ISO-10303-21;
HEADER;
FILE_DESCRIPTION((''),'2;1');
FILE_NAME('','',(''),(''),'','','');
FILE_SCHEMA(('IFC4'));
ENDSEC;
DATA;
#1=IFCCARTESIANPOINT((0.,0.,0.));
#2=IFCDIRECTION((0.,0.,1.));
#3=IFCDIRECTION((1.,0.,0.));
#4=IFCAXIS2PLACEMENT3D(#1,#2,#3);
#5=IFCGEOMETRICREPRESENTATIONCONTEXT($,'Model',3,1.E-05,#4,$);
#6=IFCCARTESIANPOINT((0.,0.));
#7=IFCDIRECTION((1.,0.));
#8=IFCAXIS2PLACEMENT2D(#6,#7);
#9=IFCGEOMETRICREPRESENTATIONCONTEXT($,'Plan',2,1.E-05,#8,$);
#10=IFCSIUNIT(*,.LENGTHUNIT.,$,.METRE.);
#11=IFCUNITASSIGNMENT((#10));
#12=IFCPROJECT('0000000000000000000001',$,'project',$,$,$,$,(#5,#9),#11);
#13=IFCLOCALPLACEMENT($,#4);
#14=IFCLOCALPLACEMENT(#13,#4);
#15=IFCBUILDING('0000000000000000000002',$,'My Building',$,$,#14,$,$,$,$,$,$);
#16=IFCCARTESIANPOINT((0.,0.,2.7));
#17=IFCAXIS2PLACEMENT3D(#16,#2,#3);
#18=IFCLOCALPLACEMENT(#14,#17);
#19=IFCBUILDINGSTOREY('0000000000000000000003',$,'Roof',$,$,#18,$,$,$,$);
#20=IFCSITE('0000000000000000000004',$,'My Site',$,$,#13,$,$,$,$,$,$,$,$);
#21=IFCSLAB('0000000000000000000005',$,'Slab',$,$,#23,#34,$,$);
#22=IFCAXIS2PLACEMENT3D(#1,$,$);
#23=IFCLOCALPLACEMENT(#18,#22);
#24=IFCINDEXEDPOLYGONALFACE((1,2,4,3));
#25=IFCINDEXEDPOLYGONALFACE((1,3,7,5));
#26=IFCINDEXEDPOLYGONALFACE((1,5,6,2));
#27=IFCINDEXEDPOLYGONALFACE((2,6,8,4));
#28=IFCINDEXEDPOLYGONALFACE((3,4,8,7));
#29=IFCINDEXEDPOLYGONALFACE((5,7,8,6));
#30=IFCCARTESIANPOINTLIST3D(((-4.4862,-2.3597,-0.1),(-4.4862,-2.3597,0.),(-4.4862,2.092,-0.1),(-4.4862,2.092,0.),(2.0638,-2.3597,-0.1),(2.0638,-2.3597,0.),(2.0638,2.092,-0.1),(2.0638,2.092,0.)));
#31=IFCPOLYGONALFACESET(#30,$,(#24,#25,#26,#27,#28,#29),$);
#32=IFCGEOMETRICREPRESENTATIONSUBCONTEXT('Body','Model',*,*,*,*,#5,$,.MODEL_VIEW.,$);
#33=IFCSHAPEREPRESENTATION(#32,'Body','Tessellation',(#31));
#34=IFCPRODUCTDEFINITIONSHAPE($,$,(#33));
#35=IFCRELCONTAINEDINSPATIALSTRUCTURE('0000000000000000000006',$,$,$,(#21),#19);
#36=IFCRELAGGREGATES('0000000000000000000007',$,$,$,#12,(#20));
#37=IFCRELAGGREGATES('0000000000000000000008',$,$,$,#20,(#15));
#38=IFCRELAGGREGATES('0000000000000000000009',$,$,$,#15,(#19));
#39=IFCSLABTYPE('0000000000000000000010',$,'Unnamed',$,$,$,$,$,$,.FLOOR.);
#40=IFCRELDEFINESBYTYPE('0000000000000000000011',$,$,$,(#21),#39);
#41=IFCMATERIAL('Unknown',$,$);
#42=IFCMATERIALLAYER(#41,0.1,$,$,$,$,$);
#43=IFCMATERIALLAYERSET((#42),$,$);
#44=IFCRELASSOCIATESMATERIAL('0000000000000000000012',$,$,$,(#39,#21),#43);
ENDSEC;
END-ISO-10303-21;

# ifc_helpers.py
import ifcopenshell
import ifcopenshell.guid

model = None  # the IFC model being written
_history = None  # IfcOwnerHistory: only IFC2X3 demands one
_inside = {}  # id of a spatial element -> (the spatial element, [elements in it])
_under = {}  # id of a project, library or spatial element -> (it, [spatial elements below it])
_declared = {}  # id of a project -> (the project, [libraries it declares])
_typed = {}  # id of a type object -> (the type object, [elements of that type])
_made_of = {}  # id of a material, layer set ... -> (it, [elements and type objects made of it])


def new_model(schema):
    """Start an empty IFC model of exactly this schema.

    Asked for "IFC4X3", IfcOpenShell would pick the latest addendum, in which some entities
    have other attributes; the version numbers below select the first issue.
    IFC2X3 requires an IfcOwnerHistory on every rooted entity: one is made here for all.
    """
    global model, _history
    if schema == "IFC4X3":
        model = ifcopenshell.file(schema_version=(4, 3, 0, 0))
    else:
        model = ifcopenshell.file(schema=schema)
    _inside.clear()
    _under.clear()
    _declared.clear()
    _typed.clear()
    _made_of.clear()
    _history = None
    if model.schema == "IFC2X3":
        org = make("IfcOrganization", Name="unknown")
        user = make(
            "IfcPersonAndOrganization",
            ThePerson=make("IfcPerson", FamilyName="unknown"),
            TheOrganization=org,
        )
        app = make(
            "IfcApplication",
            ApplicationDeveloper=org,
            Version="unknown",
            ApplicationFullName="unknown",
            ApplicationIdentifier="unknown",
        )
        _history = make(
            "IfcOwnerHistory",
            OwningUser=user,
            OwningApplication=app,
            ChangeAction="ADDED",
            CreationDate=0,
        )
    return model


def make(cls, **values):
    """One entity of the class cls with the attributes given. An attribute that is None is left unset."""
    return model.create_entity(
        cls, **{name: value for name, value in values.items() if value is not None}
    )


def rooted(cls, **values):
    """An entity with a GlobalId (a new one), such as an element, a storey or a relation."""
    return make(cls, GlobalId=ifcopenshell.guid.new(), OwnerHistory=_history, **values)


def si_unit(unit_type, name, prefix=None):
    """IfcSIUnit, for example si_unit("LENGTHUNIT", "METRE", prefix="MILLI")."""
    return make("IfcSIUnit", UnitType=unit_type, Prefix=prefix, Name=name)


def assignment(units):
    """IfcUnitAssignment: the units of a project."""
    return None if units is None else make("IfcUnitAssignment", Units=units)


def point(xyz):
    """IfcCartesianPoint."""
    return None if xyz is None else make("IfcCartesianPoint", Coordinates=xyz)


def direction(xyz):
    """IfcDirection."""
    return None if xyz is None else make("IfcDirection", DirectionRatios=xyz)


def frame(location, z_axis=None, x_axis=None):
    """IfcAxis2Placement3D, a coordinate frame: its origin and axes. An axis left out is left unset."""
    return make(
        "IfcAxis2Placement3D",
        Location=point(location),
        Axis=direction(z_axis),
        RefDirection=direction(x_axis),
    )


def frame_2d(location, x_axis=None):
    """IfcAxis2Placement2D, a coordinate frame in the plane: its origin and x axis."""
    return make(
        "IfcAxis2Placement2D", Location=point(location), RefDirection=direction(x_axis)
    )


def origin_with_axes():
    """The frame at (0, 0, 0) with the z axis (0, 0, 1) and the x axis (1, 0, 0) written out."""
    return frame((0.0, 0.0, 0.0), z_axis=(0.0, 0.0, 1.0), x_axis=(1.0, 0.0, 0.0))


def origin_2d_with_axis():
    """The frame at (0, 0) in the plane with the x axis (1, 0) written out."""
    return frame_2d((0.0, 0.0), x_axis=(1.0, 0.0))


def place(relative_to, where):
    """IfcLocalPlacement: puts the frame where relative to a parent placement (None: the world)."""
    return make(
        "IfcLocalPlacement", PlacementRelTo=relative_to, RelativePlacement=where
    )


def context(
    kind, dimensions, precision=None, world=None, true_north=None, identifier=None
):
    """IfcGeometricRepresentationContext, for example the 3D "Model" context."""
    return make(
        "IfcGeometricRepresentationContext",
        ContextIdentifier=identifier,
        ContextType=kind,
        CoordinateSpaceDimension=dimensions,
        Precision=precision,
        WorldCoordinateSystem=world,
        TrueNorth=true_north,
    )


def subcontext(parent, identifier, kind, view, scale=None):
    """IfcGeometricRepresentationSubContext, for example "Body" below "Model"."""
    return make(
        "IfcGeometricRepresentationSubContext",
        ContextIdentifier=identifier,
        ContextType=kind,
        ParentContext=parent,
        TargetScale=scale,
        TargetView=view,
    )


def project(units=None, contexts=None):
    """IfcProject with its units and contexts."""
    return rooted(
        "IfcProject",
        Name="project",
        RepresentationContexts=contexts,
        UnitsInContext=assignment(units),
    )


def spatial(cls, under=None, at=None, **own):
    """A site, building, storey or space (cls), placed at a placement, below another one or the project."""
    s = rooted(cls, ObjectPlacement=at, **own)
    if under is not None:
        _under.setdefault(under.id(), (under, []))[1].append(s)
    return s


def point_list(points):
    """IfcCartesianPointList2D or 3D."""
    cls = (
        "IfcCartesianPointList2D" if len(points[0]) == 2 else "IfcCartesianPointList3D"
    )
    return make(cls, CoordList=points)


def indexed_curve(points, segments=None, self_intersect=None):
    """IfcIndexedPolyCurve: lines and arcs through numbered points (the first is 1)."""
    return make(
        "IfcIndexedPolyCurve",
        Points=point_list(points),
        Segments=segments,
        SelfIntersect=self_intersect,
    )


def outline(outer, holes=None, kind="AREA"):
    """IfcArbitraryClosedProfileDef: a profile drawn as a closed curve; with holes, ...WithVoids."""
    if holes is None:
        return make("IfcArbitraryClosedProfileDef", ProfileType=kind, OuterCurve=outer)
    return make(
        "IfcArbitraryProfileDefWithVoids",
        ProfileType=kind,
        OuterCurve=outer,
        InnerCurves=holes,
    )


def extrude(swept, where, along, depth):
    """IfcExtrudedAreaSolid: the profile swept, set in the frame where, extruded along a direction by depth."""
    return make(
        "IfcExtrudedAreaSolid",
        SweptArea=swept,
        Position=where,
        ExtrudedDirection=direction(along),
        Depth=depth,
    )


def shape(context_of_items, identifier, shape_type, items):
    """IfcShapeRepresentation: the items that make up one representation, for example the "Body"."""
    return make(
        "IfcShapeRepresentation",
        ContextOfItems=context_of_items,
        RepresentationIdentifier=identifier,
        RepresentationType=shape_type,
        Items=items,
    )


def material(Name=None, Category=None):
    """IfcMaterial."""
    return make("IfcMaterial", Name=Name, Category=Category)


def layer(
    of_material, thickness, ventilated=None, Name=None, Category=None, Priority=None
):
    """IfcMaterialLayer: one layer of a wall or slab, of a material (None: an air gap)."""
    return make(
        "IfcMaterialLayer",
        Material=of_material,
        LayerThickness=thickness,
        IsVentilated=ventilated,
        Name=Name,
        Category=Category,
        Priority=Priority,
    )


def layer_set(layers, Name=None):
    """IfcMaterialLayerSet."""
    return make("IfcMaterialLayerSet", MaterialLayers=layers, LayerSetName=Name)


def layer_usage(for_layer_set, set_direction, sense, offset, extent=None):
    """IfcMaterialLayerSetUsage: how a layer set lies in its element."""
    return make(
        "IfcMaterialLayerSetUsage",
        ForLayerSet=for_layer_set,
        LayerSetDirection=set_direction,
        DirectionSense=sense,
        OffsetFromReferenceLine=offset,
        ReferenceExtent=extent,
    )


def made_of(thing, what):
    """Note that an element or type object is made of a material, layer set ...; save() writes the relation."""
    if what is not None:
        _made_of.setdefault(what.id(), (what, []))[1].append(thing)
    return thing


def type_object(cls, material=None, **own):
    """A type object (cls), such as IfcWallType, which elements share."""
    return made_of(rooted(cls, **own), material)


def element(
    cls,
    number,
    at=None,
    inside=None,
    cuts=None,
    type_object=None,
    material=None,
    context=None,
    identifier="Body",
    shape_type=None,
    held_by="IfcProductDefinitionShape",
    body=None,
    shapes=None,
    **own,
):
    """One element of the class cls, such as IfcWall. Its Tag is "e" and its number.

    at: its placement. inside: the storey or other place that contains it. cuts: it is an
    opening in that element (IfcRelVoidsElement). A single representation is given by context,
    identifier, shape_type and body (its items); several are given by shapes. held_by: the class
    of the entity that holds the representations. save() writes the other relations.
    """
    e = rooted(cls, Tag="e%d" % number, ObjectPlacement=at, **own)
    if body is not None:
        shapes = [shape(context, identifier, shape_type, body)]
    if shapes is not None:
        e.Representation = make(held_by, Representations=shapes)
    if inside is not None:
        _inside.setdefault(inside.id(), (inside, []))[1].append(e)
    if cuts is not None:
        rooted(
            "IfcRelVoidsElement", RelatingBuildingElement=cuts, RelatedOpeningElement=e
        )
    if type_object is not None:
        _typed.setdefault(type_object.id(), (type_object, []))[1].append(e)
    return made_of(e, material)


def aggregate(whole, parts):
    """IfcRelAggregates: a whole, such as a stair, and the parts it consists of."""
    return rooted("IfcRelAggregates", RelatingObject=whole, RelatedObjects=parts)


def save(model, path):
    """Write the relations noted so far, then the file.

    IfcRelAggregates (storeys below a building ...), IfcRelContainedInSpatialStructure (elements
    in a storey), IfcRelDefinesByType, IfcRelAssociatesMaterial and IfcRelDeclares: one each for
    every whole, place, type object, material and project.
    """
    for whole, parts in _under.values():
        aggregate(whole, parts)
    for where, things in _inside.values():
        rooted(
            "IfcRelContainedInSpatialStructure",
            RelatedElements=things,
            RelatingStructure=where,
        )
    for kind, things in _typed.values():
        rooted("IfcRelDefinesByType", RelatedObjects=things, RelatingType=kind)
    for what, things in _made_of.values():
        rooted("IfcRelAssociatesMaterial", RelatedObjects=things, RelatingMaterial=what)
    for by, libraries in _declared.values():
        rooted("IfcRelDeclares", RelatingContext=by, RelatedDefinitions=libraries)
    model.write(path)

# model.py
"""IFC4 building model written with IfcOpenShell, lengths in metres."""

from ifc_helpers import new_model, si_unit, frame, origin_with_axes, origin_2d_with_axis, place, context, subcontext, project, spatial, indexed_curve, outline, extrude, material, layer, layer_set, layer_usage, type_object, element, save


model = new_model("IFC4")

# Units and contexts
model_context = context("Model", 3, precision=1e-05, world=origin_with_axes())
plan_context = context("Plan", 2, precision=1e-05, world=origin_2d_with_axis())
body_context = subcontext(model_context, "Body", "Model", "MODEL_VIEW")
ifc_project = project(units=[si_unit("LENGTHUNIT", "METRE")], contexts=[model_context, plan_context])

# Site, building, storey
site_placement = place(None, origin_with_axes())
site = spatial("IfcSite", under=ifc_project, at=site_placement, Name="My Site")
building_placement = place(site_placement, origin_with_axes())
building = spatial("IfcBuilding", under=site, at=building_placement, Name="My Building")
storey_placement = place(building_placement, frame((0.0, 0.0, 2.7), z_axis=(0.0, 0.0, 1.0), x_axis=(1.0, 0.0, 0.0)))
storey = spatial("IfcBuildingStorey", under=building, at=storey_placement, Name="Roof")

# Slab
ifc_material = material(Name="Unknown")
ifc_layer = layer(ifc_material, 0.1)
ifc_layer_set = layer_set([ifc_layer])
ifc_layer_usage = layer_usage(ifc_layer_set, "AXIS3", "POSITIVE", -0.1)
slab_type = type_object("IfcSlabType", Name="Unnamed", PredefinedType="FLOOR", material=ifc_layer_set)
slab_placement = place(storey_placement, frame((-4.4862, 2.092, 0.0), z_axis=(0.0, 0.0, 1.0), x_axis=(1.0, 0.0, 0.0)))
element("IfcSlab", 1, at=slab_placement, inside=storey, type_object=slab_type, material=ifc_layer_usage, Name="Slab", context=body_context, shape_type="SweptSolid", body=[
    extrude(outline(indexed_curve([(0.0, 0.0), (6.55, 0.0), (6.55, -4.4516), (0.0, -4.4516), (0.0, 0.0)])), frame((0.0, 0.0, -0.1), z_axis=(0.0, 0.0, 1.0), x_axis=(1.0, 0.0, 0.0)), (0.0, 0.0, 1.0), 0.1),
])

save(model, "model.ifc")
